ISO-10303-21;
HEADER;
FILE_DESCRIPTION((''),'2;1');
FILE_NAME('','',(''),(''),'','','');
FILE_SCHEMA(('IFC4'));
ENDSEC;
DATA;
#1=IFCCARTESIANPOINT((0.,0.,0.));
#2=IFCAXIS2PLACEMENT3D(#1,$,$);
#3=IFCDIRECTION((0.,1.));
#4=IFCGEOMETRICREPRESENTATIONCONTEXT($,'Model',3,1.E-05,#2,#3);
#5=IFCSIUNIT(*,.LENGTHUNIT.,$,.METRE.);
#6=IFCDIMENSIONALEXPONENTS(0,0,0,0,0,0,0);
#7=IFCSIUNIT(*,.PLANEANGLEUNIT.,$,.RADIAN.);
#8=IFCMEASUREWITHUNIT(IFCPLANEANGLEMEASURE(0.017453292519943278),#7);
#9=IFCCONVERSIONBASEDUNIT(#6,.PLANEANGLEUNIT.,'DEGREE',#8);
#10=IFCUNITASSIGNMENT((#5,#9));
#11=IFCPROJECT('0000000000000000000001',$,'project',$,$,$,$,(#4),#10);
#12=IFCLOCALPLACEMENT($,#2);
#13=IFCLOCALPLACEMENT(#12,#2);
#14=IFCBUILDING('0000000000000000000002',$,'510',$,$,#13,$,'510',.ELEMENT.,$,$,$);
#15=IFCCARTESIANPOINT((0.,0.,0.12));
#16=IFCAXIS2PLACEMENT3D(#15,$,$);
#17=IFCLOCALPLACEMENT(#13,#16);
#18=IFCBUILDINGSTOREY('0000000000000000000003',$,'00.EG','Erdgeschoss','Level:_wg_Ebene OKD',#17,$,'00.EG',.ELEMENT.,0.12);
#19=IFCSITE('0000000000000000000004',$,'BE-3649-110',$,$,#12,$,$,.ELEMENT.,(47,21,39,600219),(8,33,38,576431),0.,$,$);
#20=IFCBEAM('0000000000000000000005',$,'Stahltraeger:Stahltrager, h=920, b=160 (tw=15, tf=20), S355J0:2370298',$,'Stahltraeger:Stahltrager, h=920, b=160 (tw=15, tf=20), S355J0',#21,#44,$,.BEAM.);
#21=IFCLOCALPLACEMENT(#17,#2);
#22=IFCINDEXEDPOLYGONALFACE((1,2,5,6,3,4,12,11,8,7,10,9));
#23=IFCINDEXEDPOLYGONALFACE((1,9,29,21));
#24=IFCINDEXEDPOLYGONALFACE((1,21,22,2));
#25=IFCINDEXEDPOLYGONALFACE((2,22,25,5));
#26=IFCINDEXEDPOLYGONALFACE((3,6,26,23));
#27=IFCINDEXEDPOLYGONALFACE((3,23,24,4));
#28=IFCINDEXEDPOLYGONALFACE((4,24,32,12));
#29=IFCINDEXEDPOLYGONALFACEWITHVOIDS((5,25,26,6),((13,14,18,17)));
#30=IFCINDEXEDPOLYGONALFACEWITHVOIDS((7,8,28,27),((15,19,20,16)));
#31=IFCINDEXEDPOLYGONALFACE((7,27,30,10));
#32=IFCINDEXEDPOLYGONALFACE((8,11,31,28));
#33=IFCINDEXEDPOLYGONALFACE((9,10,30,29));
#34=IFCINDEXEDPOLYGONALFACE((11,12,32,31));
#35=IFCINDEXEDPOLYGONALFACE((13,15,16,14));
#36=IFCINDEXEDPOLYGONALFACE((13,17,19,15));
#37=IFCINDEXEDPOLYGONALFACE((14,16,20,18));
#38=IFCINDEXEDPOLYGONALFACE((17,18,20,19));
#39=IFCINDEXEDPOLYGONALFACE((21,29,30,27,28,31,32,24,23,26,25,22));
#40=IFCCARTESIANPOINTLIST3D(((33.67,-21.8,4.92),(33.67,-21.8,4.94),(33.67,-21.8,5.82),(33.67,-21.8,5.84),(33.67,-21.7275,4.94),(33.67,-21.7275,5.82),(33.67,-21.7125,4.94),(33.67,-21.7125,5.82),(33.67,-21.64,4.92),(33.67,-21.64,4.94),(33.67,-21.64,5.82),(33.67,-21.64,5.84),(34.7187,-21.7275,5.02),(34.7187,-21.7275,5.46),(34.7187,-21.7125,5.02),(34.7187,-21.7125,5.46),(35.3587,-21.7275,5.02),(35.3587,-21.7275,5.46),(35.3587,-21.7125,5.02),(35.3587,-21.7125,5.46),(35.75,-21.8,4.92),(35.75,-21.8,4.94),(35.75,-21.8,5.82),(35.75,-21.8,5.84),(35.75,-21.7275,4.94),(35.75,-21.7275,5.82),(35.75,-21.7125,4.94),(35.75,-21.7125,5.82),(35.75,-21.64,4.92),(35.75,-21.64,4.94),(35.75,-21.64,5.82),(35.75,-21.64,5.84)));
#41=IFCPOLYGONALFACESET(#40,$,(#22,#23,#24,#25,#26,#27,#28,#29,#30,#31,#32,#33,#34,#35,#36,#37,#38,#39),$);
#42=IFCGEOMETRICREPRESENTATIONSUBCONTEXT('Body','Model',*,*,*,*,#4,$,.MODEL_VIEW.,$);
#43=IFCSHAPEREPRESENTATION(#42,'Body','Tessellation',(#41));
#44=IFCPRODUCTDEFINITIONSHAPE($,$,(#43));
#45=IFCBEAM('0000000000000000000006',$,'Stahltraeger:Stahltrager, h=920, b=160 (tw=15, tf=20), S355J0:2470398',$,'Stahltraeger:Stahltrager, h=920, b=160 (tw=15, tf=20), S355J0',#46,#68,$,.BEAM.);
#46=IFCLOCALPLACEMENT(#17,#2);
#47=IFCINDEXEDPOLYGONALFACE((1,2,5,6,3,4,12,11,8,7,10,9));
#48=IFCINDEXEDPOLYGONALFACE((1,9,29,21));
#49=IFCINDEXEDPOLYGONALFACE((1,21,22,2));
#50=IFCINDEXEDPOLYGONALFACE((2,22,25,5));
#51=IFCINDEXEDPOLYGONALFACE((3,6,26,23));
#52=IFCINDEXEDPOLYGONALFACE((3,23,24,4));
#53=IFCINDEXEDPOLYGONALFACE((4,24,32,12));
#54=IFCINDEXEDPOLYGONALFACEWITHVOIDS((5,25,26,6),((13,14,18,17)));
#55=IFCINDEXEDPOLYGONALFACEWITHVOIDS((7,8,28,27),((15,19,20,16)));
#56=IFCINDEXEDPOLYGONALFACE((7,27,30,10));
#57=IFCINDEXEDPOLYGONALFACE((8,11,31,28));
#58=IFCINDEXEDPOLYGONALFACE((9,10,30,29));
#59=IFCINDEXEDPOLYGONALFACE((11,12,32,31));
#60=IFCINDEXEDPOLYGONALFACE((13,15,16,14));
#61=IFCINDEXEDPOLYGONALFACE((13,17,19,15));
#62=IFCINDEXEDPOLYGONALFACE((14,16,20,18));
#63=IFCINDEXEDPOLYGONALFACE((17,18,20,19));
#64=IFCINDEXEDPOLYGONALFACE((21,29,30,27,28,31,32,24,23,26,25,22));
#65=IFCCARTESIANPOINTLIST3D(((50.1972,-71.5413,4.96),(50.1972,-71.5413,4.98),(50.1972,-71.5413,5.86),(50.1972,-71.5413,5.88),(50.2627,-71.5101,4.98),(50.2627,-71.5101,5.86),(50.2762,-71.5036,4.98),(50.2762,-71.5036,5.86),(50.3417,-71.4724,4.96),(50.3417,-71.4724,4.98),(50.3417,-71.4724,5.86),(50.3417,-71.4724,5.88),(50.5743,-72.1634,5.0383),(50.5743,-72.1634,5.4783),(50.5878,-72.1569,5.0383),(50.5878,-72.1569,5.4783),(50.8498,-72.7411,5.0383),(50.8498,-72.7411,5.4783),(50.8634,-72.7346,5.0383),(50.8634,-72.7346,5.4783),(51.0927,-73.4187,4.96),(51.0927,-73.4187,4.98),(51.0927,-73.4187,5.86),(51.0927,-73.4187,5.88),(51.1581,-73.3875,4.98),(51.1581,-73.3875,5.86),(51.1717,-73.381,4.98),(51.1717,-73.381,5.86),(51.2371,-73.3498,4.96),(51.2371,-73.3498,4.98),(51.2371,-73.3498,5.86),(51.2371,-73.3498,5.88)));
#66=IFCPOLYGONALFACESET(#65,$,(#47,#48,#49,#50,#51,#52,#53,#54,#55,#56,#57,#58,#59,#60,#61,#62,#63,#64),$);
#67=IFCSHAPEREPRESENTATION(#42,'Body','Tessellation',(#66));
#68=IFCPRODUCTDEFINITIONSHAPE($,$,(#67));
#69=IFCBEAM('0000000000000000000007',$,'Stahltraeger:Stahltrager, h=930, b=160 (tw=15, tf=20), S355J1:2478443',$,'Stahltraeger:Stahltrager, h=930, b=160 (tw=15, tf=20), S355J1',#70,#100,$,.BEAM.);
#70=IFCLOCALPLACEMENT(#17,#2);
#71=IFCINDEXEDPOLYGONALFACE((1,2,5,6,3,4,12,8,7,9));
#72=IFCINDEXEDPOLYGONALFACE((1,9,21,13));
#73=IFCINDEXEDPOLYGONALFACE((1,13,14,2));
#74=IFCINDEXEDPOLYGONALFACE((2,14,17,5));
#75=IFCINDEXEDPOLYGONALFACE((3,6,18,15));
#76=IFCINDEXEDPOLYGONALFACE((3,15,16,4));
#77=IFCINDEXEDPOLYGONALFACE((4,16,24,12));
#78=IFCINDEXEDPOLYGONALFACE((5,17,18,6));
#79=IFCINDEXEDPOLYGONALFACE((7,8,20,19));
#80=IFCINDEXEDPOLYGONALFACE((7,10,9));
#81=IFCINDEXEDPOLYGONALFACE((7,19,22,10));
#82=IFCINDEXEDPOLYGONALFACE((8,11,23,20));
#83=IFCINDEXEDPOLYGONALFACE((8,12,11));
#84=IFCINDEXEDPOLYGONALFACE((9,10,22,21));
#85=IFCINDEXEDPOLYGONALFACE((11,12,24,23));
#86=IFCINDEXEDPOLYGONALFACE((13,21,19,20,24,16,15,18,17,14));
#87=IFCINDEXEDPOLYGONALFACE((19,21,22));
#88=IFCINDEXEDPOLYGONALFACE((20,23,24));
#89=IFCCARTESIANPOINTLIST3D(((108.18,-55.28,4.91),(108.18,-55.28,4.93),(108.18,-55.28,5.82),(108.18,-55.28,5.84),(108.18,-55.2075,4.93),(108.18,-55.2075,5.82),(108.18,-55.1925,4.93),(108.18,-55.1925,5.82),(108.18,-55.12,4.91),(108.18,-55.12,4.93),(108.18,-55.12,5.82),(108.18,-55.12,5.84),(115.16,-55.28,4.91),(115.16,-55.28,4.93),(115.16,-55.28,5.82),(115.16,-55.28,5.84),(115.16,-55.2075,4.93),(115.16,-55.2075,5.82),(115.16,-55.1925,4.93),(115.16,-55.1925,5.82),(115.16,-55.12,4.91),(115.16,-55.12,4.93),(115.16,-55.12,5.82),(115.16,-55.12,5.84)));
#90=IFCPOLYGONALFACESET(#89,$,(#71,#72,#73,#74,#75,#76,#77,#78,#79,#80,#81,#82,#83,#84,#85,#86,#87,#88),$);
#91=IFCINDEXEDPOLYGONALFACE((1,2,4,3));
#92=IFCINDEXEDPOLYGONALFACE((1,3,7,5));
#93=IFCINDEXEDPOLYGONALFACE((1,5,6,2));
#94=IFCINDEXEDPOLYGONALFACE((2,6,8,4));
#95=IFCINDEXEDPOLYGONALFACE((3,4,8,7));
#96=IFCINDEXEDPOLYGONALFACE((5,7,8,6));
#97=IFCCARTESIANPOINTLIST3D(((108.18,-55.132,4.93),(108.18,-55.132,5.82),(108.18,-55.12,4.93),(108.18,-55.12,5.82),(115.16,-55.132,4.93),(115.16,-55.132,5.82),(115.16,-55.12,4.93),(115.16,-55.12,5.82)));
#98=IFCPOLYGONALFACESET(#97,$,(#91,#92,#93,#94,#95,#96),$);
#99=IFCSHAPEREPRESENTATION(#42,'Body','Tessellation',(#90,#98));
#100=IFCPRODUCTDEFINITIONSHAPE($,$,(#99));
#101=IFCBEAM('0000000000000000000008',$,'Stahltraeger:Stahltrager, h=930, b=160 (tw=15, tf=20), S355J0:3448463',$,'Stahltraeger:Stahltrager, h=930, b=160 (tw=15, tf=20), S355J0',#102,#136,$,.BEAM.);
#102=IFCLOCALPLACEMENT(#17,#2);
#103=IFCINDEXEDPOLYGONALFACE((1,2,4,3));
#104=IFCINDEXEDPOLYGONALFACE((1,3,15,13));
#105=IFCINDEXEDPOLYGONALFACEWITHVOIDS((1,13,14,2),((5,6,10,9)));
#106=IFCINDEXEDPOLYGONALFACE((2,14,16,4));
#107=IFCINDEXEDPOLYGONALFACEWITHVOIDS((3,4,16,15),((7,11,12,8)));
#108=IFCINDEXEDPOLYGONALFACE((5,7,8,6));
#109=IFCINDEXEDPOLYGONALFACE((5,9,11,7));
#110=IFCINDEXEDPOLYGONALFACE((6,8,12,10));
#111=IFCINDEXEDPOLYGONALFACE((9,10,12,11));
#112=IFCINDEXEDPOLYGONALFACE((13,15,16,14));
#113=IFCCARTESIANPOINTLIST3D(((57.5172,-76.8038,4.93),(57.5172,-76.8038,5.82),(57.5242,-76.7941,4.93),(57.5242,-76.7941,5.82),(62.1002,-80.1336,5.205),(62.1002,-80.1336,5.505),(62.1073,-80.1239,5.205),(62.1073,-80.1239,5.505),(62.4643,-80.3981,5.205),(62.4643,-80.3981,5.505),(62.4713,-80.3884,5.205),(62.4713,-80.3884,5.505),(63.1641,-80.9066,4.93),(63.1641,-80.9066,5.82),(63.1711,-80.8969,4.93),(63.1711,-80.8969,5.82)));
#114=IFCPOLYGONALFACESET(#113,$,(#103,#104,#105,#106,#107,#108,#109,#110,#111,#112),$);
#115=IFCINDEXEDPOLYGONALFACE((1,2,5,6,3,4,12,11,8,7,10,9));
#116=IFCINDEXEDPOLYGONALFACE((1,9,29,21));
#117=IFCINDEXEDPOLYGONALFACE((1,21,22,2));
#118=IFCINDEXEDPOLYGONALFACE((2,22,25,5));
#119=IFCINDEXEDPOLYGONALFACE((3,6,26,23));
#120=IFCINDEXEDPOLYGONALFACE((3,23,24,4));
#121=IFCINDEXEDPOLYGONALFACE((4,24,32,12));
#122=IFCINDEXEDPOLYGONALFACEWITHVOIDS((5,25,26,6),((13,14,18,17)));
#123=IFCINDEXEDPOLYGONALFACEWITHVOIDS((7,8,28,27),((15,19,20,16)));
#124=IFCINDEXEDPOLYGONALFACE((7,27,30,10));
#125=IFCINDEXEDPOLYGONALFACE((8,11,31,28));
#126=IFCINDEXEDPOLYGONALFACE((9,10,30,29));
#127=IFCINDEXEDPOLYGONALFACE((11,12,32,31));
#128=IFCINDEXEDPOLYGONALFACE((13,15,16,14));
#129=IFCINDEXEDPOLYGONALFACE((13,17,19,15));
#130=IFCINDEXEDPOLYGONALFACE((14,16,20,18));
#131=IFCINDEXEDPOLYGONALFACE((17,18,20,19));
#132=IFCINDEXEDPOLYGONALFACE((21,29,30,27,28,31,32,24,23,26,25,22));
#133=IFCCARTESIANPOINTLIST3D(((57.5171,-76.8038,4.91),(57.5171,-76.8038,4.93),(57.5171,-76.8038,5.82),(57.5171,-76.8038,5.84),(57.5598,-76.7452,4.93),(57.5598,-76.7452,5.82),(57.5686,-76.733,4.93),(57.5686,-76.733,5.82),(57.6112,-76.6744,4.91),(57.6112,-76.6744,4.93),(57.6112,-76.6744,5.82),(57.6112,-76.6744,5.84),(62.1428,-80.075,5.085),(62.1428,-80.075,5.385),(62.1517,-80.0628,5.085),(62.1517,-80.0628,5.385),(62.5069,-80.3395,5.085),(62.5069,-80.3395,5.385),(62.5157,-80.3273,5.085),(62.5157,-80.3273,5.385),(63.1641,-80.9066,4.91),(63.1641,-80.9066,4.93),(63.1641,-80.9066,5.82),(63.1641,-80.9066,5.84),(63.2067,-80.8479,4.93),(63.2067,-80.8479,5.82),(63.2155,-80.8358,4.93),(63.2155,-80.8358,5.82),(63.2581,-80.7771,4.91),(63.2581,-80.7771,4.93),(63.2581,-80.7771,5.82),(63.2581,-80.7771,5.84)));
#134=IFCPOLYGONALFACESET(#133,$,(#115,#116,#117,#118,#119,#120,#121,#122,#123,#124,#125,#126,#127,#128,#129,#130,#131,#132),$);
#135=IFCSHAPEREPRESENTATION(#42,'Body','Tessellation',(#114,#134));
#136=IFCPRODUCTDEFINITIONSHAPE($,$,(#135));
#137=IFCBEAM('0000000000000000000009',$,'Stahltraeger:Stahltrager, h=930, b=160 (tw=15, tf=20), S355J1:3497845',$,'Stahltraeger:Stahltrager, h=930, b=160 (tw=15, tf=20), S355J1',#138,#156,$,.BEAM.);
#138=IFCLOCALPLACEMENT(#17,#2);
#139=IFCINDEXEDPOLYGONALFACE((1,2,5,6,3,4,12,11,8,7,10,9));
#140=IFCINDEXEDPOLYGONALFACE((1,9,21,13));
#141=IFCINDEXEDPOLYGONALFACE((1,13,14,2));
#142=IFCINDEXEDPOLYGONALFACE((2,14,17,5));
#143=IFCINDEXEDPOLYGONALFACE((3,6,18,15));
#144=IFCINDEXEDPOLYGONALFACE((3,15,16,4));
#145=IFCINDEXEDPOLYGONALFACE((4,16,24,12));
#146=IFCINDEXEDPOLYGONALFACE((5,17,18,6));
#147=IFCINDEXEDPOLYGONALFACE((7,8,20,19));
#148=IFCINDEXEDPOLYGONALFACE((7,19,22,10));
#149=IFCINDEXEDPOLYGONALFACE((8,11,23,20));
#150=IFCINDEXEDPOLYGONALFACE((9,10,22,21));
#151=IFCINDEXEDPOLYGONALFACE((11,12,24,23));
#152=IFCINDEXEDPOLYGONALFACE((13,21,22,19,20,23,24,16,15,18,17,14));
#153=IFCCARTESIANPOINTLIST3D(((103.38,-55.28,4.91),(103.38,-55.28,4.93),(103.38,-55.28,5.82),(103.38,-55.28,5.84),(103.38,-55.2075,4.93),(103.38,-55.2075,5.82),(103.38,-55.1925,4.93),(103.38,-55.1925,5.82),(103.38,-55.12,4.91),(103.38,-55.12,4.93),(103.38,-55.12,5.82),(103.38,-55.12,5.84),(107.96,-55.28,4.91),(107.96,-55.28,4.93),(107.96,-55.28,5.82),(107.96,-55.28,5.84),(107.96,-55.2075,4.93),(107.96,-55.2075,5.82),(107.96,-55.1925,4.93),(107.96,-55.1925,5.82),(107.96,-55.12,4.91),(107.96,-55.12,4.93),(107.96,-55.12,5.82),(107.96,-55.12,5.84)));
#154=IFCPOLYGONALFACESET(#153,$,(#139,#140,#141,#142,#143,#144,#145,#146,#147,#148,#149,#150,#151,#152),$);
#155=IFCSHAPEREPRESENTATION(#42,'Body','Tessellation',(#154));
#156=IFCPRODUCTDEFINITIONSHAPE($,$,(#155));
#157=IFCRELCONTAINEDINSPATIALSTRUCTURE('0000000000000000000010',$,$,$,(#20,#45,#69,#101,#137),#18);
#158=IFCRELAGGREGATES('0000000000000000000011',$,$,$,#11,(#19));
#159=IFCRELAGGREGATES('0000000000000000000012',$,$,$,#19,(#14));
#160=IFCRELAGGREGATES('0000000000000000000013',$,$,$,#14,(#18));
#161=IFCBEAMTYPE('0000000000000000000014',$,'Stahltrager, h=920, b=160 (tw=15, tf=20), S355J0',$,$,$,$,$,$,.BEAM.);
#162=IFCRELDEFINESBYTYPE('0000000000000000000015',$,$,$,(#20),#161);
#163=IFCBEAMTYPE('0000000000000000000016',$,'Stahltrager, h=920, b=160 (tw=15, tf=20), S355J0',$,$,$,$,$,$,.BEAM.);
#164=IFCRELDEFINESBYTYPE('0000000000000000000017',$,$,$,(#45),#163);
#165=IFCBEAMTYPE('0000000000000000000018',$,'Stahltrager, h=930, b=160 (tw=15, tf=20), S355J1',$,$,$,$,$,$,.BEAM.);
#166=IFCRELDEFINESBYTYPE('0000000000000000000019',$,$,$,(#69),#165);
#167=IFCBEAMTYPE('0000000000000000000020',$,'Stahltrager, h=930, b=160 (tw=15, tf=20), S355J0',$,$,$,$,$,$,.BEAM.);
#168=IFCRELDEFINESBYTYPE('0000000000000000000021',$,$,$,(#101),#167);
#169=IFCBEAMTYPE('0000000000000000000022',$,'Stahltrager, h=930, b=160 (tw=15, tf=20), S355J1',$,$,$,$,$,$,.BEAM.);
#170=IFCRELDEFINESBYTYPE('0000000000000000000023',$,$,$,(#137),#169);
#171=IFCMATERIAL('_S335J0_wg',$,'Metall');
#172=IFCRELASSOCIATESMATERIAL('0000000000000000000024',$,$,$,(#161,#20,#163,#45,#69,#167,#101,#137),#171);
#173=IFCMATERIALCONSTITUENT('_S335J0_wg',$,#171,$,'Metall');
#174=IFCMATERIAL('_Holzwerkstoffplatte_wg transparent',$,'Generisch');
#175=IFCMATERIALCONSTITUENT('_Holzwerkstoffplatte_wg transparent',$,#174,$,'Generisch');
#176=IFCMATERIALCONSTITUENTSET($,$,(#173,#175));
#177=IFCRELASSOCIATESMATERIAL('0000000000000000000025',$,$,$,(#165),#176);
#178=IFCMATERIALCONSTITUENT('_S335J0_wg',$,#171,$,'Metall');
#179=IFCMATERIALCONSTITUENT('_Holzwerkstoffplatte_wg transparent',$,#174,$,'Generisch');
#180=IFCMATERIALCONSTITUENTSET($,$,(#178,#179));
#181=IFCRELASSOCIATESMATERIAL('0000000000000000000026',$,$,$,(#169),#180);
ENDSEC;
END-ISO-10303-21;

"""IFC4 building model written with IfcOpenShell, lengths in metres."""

from ifc_helpers import new_model, entity, si_unit, converted_unit, direction, frame, origin, place, context, subcontext, project, spatial, indexed_curve, outline, extrude, source, transform, mapped, material, constituent, constituent_set, type_object, type_shapes, element, save


model = new_model("IFC4")

# Units and contexts
model_context = context("Model", 3, precision=1e-05, world=origin(), true_north=direction((0.0, 1.0)))
body_context = subcontext(model_context, "Body", "Model", "MODEL_VIEW")
ifc_project = project(units=[si_unit("LENGTHUNIT", "METRE"), converted_unit("PLANEANGLEUNIT", "DEGREE", entity("IfcPlaneAngleMeasure", 0.017453292519943278), si_unit("PLANEANGLEUNIT", "RADIAN"), dimensions=[0, 0, 0, 0, 0, 0, 0])], contexts=[model_context])

# Site, building, storey
site_placement = place(None, origin())
site = spatial("IfcSite", under=ifc_project, at=site_placement, Name="BE-3649-110", CompositionType="ELEMENT", RefLatitude=(47, 21, 39, 600219), RefLongitude=(8, 33, 38, 576431), RefElevation=0.0)
building_placement = place(site_placement, origin())
building = spatial("IfcBuilding", under=site, at=building_placement, Name="510", LongName="510", CompositionType="ELEMENT")
storey_placement = place(building_placement, frame((0.0, 0.0, 0.12)))
storey = spatial("IfcBuildingStorey", under=building, at=storey_placement, Name="00.EG", Description="Erdgeschoss", ObjectType="Level:_wg_Ebene OKD", LongName="00.EG", CompositionType="ELEMENT", Elevation=0.12)

# Beams, openings
ifc_material_1 = material(Name="_S335J0_wg", Category="Metall")
beam_type_1 = type_object("IfcBeamType", Name="Stahltrager, h=920, b=160 (tw=15, tf=20), S355J0", PredefinedType="BEAM", material=ifc_material_1)
shared_shape_1 = source(origin(), body_context, "Body", "SweptSolid", [
    extrude(outline(indexed_curve([(-0.08, -0.44), (-0.08, -0.46), (0.08, -0.46), (0.08, -0.44), (0.0075, -0.44), (0.0075, 0.44), (0.08, 0.44), (0.08, 0.46), (-0.08, 0.46), (-0.08, 0.44), (-0.0075, 0.44), (-0.0075, -0.44), (-0.08, -0.44)], self_intersect=False)), frame((0.0, 0.08, 0.46), z_axis=(-1.0, 0.0, 0.0), x_axis=(0.0, -1.0, 0.0)), (0.0, 0.0, -1.0), 2.08),
])
type_shapes(beam_type_1, [shared_shape_1])
beam_1_placement = place(storey_placement, frame((33.67, -21.8, 4.92)))
beam_1 = element("IfcBeam", 1, at=beam_1_placement, inside=storey, type_object=beam_type_1, material=ifc_material_1, Name="Stahltraeger:Stahltrager, h=920, b=160 (tw=15, tf=20), S355J0:2370298", ObjectType="Stahltraeger:Stahltrager, h=920, b=160 (tw=15, tf=20), S355J0", PredefinedType="BEAM", context=body_context, shape_type="MappedRepresentation", body=[
    mapped(shared_shape_1, transform((0.0, 0.0, 0.0), scale=1.0)),
])
opening_1_placement = place(storey_placement, frame((33.67, -21.8, 4.92)))
element("IfcOpeningElement", 2, at=opening_1_placement, cuts=beam_1, PredefinedType="OPENING", context=body_context, shape_type="SweptSolid", body=[
    extrude(outline(indexed_curve([(-0.32, -0.22), (0.32, -0.22), (0.32, 0.22), (-0.32, 0.22), (-0.32, -0.22)], self_intersect=False)), frame((1.3687, 0.0725, 0.32), z_axis=(0.0, 1.0, 0.0), x_axis=(-1.0, 0.0, 0.0)), (0.0, 0.0, 1.0), 0.015),
])
beam_type_2 = type_object("IfcBeamType", Name="Stahltrager, h=920, b=160 (tw=15, tf=20), S355J0", PredefinedType="BEAM", material=ifc_material_1)
shared_shape_2 = source(origin(), body_context, "Body", "SweptSolid", [
    extrude(outline(indexed_curve([(-0.08, -0.44), (-0.08, -0.46), (0.08, -0.46), (0.08, -0.44), (0.0075, -0.44), (0.0075, 0.44), (0.08, 0.44), (0.08, 0.46), (-0.08, 0.46), (-0.08, 0.44), (-0.0075, 0.44), (-0.0075, -0.44), (-0.08, -0.44)], self_intersect=False)), frame((0.9677, 0.0344, 0.46), z_axis=(0.430511, -0.902585, 0.0), x_axis=(0.902585, 0.430511, 0.0)), (0.0, 0.0, -1.0), 2.08),
])
type_shapes(beam_type_2, [shared_shape_2])
beam_2_placement = place(storey_placement, frame((50.1972, -73.4187, 4.96)))
beam_2 = element("IfcBeam", 3, at=beam_2_placement, inside=storey, type_object=beam_type_2, material=ifc_material_1, Name="Stahltraeger:Stahltrager, h=920, b=160 (tw=15, tf=20), S355J0:2470398", ObjectType="Stahltraeger:Stahltrager, h=920, b=160 (tw=15, tf=20), S355J0", PredefinedType="BEAM", context=body_context, shape_type="MappedRepresentation", body=[
    mapped(shared_shape_2, transform((0.0, 0.0, 0.0), scale=1.0)),
])
opening_2_placement = place(storey_placement, frame((50.1972, -73.4187, 4.96)))
element("IfcOpeningElement", 4, at=opening_2_placement, cuts=beam_2, PredefinedType="OPENING", context=body_context, shape_type="SweptSolid", body=[
    extrude(outline(indexed_curve([(-0.32, -0.22), (0.32, -0.22), (0.32, 0.22), (-0.32, 0.22), (-0.32, -0.22)], self_intersect=False)), frame((0.5284, 0.9729, 0.2983), z_axis=(-0.902585, -0.430511, 0.0), x_axis=(0.430511, -0.902585, 0.0)), (0.0, 0.0, 1.0), 0.015),
])

# Beam
ifc_constituent_1 = constituent(ifc_material_1, Name="_S335J0_wg", Category="Metall")
ifc_material_2 = material(Name="_Holzwerkstoffplatte_wg transparent", Category="Generisch")
ifc_constituent_2 = constituent(ifc_material_2, Name="_Holzwerkstoffplatte_wg transparent", Category="Generisch")
ifc_constituent_set_1 = constituent_set(constituents=[ifc_constituent_1, ifc_constituent_2])
beam_type_3 = type_object("IfcBeamType", Name="Stahltrager, h=930, b=160 (tw=15, tf=20), S355J1", PredefinedType="BEAM", material=ifc_constituent_set_1)
shared_shape_3 = source(origin(), body_context, "Body", "SweptSolid", [
    extrude(outline(indexed_curve([(-0.465, -0.08), (-0.445, -0.08), (-0.445, -0.0075), (0.445, -0.0075), (0.445, -0.08), (0.465, -0.08), (0.465, 0.08), (0.445, 0.08), (0.445, 0.0075), (-0.445, 0.0075), (-0.445, 0.08), (-0.465, 0.08), (-0.465, -0.08)], self_intersect=False)), frame((-3.49, 0.0, 0.0), z_axis=(1.0, 0.0, 0.0), x_axis=(0.0, 0.0, -1.0)), (0.0, 0.0, 1.0), 6.98),
    extrude(outline(indexed_curve([(-0.445, -0.006), (0.445, -0.006), (0.445, 0.006), (-0.445, 0.006), (-0.445, -0.006)], self_intersect=False)), frame((-3.49, 0.074, 0.0), z_axis=(1.0, 0.0, 0.0), x_axis=(0.0, 0.0, -1.0)), (0.0, 0.0, 1.0), 6.98),
])
type_shapes(beam_type_3, [shared_shape_3])
beam_3_placement = place(storey_placement, frame((111.67, -55.2, 5.375)))
element("IfcBeam", 5, at=beam_3_placement, inside=storey, type_object=beam_type_3, material=ifc_material_1, Name="Stahltraeger:Stahltrager, h=930, b=160 (tw=15, tf=20), S355J1:2478443", ObjectType="Stahltraeger:Stahltrager, h=930, b=160 (tw=15, tf=20), S355J1", PredefinedType="BEAM", context=body_context, shape_type="MappedRepresentation", body=[
    mapped(shared_shape_3, transform((0.0, 0.0, 0.0), scale=1.0)),
])

# Beam, opening
beam_type_4 = type_object("IfcBeamType", Name="Stahltrager, h=930, b=160 (tw=15, tf=20), S355J0", PredefinedType="BEAM", material=ifc_material_1)
shared_shape_4 = source(origin(), body_context, "Body", "SweptSolid", [
    extrude(outline(indexed_curve([(-3.49, -0.445), (3.49, -0.445), (3.49, 0.445), (-3.49, 0.445), (-3.49, -0.445)], self_intersect=False), holes=[indexed_curve([(-2.175, 0.13), (-2.175, -0.17), (-2.625, -0.17), (-2.625, 0.13), (-2.175, 0.13)], self_intersect=False)]), frame((2.8235, 2.0514, 0.465), z_axis=(0.587785, 0.809017, 0.0), x_axis=(-0.809017, 0.587785, 0.0)), (0.0, 0.0, 1.0), 0.012),
    extrude(outline(indexed_curve([(-0.08, -0.445), (-0.08, -0.465), (0.08, -0.465), (0.08, -0.445), (0.0075, -0.445), (0.0075, 0.445), (0.08, 0.445), (0.08, 0.465), (-0.08, 0.465), (-0.08, 0.445), (-0.0075, 0.445), (-0.0075, -0.445), (-0.08, -0.445)], self_intersect=False)), frame((0.047, 4.1675, 0.465), z_axis=(-0.809017, 0.587785, 0.0), x_axis=(-0.587785, -0.809017, 0.0)), (0.0, 0.0, -1.0), 6.98),
])
type_shapes(beam_type_4, [shared_shape_4])
beam_4_placement = place(storey_placement, frame((57.5171, -80.9066, 4.91)))
beam_4 = element("IfcBeam", 6, at=beam_4_placement, inside=storey, type_object=beam_type_4, material=ifc_material_1, Name="Stahltraeger:Stahltrager, h=930, b=160 (tw=15, tf=20), S355J0:3448463", ObjectType="Stahltraeger:Stahltrager, h=930, b=160 (tw=15, tf=20), S355J0", PredefinedType="BEAM", context=body_context, shape_type="MappedRepresentation", body=[
    mapped(shared_shape_4, transform((0.0, 0.0, 0.0), scale=1.0)),
])
opening_3_placement = place(storey_placement, frame((57.5171, -80.9066, 4.91)))
element("IfcOpeningElement", 7, at=opening_3_placement, cuts=beam_4, PredefinedType="OPENING", context=body_context, shape_type="SweptSolid", body=[
    extrude(outline(indexed_curve([(-0.225, -0.15), (0.225, -0.15), (0.225, 0.15), (-0.225, 0.15), (-0.225, -0.15)], self_intersect=False)), frame((4.8077, 0.6993, 0.325), z_axis=(0.587785, 0.809017, 0.0), x_axis=(0.809017, -0.587785, 0.0)), (0.0, 0.0, 1.0), 0.015),
])

# Beam
ifc_constituent_3 = constituent(ifc_material_1, Name="_S335J0_wg", Category="Metall")
ifc_constituent_4 = constituent(ifc_material_2, Name="_Holzwerkstoffplatte_wg transparent", Category="Generisch")
ifc_constituent_set_2 = constituent_set(constituents=[ifc_constituent_3, ifc_constituent_4])
beam_type_5 = type_object("IfcBeamType", Name="Stahltrager, h=930, b=160 (tw=15, tf=20), S355J1", PredefinedType="BEAM", material=ifc_constituent_set_2)
shared_shape_5 = source(origin(), body_context, "Body", "SweptSolid", [
    extrude(outline(indexed_curve([(-0.465, -0.08), (-0.445, -0.08), (-0.445, -0.0075), (0.445, -0.0075), (0.445, -0.08), (0.465, -0.08), (0.465, 0.08), (0.445, 0.08), (0.445, 0.0075), (-0.445, 0.0075), (-0.445, 0.08), (-0.465, 0.08), (-0.465, -0.08)], self_intersect=False)), frame((-2.29, 0.0, 0.0), z_axis=(1.0, 0.0, 0.0), x_axis=(0.0, 0.0, -1.0)), (0.0, 0.0, 1.0), 4.58),
])
type_shapes(beam_type_5, [shared_shape_5])
beam_5_placement = place(storey_placement, frame((105.67, -55.2, 5.375)))
element("IfcBeam", 8, at=beam_5_placement, inside=storey, type_object=beam_type_5, material=ifc_material_1, Name="Stahltraeger:Stahltrager, h=930, b=160 (tw=15, tf=20), S355J1:3497845", ObjectType="Stahltraeger:Stahltrager, h=930, b=160 (tw=15, tf=20), S355J1", PredefinedType="BEAM", context=body_context, shape_type="MappedRepresentation", body=[
    mapped(shared_shape_5, transform((0.0, 0.0, 0.0), scale=1.0)),
])

save(model, "model.ifc")
